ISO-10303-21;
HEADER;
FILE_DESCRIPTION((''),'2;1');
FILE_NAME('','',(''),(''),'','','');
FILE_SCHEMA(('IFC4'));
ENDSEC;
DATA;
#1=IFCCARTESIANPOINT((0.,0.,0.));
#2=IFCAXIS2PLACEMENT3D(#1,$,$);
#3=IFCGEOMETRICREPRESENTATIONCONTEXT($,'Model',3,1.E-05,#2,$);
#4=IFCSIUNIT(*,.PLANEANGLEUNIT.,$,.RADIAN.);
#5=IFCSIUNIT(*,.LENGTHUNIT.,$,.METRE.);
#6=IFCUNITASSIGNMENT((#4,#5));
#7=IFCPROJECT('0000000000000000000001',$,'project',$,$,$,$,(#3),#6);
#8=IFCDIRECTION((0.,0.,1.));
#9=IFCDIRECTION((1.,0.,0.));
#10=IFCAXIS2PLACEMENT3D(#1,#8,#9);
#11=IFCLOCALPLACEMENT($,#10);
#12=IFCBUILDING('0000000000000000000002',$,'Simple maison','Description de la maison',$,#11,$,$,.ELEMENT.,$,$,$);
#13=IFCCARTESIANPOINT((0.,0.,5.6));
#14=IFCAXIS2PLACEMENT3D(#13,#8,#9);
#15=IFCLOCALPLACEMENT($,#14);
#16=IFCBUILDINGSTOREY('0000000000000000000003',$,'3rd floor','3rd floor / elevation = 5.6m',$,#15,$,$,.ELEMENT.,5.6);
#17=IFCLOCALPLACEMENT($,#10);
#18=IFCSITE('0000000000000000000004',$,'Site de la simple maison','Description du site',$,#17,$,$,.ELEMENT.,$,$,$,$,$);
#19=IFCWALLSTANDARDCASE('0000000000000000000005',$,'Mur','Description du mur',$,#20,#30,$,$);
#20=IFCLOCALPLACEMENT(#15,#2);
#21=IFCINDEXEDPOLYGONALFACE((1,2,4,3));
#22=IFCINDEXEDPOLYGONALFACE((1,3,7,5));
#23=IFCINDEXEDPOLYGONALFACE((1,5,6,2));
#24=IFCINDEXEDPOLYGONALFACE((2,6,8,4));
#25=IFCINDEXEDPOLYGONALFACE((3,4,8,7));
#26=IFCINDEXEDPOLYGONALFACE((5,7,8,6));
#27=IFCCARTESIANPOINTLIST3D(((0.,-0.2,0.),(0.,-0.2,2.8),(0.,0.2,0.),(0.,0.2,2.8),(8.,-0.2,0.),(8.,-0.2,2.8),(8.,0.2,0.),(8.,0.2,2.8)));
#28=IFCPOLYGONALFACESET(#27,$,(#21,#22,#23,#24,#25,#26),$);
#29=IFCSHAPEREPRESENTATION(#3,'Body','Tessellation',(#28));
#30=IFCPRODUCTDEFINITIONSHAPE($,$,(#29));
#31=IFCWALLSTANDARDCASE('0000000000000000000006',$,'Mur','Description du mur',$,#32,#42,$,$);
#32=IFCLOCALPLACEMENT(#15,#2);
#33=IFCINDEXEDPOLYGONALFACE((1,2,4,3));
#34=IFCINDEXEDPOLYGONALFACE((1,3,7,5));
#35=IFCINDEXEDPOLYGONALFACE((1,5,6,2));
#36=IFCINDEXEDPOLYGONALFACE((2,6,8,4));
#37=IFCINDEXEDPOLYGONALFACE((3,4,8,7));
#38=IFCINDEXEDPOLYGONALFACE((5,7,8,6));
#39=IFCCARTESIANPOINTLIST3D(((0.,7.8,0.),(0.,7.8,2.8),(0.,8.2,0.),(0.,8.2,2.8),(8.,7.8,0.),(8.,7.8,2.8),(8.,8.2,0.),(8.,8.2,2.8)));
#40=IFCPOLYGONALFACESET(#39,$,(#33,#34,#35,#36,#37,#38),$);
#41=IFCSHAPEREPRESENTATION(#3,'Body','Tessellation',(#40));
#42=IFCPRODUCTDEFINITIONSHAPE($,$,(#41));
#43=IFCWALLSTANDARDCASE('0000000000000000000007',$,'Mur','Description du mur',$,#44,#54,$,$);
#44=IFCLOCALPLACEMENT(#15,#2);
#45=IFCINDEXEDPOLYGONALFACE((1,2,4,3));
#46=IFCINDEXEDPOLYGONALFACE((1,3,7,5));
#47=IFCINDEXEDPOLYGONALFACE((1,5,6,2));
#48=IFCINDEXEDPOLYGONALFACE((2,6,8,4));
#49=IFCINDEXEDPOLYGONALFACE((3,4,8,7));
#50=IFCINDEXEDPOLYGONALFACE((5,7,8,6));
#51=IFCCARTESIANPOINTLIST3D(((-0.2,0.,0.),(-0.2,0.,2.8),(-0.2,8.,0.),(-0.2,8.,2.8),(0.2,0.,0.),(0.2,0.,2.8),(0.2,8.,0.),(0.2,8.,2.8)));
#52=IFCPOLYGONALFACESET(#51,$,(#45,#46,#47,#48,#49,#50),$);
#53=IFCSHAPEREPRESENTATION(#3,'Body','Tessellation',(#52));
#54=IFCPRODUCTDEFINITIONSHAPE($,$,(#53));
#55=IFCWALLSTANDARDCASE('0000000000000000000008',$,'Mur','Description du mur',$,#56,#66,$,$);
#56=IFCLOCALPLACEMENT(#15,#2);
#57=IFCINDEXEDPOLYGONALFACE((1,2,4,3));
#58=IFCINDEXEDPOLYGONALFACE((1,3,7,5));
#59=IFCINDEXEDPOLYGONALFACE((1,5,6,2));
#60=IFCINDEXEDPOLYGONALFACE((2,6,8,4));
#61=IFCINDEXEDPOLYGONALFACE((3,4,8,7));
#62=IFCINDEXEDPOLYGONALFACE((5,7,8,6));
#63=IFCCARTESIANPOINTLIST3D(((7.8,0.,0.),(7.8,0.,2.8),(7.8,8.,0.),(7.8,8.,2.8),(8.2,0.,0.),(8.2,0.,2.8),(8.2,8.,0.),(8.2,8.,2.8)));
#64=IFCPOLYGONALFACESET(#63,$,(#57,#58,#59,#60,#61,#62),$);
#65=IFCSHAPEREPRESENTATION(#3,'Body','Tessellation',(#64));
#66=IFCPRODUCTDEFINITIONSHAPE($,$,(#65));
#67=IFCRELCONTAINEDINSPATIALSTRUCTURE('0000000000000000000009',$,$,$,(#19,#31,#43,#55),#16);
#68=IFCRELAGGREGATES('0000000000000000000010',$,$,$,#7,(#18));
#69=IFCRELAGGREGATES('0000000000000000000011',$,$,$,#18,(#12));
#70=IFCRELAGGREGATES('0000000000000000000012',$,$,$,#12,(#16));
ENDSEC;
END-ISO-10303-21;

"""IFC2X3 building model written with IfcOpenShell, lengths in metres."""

from ifc_helpers import new_model, si_unit, frame, origin, origin_with_axes, place, context, project, spatial, polyline, outline, extrude, element, save


model = new_model("IFC2X3")

# Units and contexts
model_context = context("Model", 3, precision=1e-05, world=origin())
ifc_project = project(units=[si_unit("PLANEANGLEUNIT", "RADIAN"), si_unit("LENGTHUNIT", "METRE")], contexts=[model_context])

# Site, building, storey
site_placement = place(None, origin_with_axes())
site = spatial("IfcSite", under=ifc_project, at=site_placement, Name="Site de la simple maison", Description="Description du site", CompositionType="ELEMENT")
building_placement = place(None, origin_with_axes())
building = spatial("IfcBuilding", under=site, at=building_placement, Name="Simple maison", Description="Description de la maison", CompositionType="ELEMENT")
storey_placement = place(None, frame((0.0, 0.0, 5.6), z_axis=(0.0, 0.0, 1.0), x_axis=(1.0, 0.0, 0.0)))
storey = spatial("IfcBuildingStorey", under=building, at=storey_placement, Name="3rd floor", Description="3rd floor / elevation = 5.6m", CompositionType="ELEMENT", Elevation=5.6)

# Walls
for number, where, z_axis, x_axis, name in (
    (1, (0.0, 0.0, 0.0), (0.0, 0.0, 1.0), (1.0, 0.0, 0.0), "Mur"),
    (2, (0.0, 8.0, 0.0), (0.0, 0.0, 1.0), (1.0, 0.0, 0.0), "Mur"),
    (3, (0.0, 0.0, 0.0), (0.0, 0.0, 1.0), (0.0, 1.0, 0.0), "Mur"),
    (4, (8.0, 0.0, 0.0), (0.0, 0.0, 1.0), (0.0, 1.0, 0.0), "Mur"),
):
    element("IfcWallStandardCase", number, at=place(storey_placement, frame(where, z_axis=z_axis, x_axis=x_axis)), inside=storey, Name=name, Description="Description du mur", context=model_context, shape_type="SweptSolid", body=[
        extrude(outline(polyline([(0.0, 0.2), (8.0, 0.2), (8.0, -0.2), (0.0, -0.2)])), origin_with_axes(), (0.0, 0.0, 1.0), 2.8),
    ])

save(model, "model.ifc")
